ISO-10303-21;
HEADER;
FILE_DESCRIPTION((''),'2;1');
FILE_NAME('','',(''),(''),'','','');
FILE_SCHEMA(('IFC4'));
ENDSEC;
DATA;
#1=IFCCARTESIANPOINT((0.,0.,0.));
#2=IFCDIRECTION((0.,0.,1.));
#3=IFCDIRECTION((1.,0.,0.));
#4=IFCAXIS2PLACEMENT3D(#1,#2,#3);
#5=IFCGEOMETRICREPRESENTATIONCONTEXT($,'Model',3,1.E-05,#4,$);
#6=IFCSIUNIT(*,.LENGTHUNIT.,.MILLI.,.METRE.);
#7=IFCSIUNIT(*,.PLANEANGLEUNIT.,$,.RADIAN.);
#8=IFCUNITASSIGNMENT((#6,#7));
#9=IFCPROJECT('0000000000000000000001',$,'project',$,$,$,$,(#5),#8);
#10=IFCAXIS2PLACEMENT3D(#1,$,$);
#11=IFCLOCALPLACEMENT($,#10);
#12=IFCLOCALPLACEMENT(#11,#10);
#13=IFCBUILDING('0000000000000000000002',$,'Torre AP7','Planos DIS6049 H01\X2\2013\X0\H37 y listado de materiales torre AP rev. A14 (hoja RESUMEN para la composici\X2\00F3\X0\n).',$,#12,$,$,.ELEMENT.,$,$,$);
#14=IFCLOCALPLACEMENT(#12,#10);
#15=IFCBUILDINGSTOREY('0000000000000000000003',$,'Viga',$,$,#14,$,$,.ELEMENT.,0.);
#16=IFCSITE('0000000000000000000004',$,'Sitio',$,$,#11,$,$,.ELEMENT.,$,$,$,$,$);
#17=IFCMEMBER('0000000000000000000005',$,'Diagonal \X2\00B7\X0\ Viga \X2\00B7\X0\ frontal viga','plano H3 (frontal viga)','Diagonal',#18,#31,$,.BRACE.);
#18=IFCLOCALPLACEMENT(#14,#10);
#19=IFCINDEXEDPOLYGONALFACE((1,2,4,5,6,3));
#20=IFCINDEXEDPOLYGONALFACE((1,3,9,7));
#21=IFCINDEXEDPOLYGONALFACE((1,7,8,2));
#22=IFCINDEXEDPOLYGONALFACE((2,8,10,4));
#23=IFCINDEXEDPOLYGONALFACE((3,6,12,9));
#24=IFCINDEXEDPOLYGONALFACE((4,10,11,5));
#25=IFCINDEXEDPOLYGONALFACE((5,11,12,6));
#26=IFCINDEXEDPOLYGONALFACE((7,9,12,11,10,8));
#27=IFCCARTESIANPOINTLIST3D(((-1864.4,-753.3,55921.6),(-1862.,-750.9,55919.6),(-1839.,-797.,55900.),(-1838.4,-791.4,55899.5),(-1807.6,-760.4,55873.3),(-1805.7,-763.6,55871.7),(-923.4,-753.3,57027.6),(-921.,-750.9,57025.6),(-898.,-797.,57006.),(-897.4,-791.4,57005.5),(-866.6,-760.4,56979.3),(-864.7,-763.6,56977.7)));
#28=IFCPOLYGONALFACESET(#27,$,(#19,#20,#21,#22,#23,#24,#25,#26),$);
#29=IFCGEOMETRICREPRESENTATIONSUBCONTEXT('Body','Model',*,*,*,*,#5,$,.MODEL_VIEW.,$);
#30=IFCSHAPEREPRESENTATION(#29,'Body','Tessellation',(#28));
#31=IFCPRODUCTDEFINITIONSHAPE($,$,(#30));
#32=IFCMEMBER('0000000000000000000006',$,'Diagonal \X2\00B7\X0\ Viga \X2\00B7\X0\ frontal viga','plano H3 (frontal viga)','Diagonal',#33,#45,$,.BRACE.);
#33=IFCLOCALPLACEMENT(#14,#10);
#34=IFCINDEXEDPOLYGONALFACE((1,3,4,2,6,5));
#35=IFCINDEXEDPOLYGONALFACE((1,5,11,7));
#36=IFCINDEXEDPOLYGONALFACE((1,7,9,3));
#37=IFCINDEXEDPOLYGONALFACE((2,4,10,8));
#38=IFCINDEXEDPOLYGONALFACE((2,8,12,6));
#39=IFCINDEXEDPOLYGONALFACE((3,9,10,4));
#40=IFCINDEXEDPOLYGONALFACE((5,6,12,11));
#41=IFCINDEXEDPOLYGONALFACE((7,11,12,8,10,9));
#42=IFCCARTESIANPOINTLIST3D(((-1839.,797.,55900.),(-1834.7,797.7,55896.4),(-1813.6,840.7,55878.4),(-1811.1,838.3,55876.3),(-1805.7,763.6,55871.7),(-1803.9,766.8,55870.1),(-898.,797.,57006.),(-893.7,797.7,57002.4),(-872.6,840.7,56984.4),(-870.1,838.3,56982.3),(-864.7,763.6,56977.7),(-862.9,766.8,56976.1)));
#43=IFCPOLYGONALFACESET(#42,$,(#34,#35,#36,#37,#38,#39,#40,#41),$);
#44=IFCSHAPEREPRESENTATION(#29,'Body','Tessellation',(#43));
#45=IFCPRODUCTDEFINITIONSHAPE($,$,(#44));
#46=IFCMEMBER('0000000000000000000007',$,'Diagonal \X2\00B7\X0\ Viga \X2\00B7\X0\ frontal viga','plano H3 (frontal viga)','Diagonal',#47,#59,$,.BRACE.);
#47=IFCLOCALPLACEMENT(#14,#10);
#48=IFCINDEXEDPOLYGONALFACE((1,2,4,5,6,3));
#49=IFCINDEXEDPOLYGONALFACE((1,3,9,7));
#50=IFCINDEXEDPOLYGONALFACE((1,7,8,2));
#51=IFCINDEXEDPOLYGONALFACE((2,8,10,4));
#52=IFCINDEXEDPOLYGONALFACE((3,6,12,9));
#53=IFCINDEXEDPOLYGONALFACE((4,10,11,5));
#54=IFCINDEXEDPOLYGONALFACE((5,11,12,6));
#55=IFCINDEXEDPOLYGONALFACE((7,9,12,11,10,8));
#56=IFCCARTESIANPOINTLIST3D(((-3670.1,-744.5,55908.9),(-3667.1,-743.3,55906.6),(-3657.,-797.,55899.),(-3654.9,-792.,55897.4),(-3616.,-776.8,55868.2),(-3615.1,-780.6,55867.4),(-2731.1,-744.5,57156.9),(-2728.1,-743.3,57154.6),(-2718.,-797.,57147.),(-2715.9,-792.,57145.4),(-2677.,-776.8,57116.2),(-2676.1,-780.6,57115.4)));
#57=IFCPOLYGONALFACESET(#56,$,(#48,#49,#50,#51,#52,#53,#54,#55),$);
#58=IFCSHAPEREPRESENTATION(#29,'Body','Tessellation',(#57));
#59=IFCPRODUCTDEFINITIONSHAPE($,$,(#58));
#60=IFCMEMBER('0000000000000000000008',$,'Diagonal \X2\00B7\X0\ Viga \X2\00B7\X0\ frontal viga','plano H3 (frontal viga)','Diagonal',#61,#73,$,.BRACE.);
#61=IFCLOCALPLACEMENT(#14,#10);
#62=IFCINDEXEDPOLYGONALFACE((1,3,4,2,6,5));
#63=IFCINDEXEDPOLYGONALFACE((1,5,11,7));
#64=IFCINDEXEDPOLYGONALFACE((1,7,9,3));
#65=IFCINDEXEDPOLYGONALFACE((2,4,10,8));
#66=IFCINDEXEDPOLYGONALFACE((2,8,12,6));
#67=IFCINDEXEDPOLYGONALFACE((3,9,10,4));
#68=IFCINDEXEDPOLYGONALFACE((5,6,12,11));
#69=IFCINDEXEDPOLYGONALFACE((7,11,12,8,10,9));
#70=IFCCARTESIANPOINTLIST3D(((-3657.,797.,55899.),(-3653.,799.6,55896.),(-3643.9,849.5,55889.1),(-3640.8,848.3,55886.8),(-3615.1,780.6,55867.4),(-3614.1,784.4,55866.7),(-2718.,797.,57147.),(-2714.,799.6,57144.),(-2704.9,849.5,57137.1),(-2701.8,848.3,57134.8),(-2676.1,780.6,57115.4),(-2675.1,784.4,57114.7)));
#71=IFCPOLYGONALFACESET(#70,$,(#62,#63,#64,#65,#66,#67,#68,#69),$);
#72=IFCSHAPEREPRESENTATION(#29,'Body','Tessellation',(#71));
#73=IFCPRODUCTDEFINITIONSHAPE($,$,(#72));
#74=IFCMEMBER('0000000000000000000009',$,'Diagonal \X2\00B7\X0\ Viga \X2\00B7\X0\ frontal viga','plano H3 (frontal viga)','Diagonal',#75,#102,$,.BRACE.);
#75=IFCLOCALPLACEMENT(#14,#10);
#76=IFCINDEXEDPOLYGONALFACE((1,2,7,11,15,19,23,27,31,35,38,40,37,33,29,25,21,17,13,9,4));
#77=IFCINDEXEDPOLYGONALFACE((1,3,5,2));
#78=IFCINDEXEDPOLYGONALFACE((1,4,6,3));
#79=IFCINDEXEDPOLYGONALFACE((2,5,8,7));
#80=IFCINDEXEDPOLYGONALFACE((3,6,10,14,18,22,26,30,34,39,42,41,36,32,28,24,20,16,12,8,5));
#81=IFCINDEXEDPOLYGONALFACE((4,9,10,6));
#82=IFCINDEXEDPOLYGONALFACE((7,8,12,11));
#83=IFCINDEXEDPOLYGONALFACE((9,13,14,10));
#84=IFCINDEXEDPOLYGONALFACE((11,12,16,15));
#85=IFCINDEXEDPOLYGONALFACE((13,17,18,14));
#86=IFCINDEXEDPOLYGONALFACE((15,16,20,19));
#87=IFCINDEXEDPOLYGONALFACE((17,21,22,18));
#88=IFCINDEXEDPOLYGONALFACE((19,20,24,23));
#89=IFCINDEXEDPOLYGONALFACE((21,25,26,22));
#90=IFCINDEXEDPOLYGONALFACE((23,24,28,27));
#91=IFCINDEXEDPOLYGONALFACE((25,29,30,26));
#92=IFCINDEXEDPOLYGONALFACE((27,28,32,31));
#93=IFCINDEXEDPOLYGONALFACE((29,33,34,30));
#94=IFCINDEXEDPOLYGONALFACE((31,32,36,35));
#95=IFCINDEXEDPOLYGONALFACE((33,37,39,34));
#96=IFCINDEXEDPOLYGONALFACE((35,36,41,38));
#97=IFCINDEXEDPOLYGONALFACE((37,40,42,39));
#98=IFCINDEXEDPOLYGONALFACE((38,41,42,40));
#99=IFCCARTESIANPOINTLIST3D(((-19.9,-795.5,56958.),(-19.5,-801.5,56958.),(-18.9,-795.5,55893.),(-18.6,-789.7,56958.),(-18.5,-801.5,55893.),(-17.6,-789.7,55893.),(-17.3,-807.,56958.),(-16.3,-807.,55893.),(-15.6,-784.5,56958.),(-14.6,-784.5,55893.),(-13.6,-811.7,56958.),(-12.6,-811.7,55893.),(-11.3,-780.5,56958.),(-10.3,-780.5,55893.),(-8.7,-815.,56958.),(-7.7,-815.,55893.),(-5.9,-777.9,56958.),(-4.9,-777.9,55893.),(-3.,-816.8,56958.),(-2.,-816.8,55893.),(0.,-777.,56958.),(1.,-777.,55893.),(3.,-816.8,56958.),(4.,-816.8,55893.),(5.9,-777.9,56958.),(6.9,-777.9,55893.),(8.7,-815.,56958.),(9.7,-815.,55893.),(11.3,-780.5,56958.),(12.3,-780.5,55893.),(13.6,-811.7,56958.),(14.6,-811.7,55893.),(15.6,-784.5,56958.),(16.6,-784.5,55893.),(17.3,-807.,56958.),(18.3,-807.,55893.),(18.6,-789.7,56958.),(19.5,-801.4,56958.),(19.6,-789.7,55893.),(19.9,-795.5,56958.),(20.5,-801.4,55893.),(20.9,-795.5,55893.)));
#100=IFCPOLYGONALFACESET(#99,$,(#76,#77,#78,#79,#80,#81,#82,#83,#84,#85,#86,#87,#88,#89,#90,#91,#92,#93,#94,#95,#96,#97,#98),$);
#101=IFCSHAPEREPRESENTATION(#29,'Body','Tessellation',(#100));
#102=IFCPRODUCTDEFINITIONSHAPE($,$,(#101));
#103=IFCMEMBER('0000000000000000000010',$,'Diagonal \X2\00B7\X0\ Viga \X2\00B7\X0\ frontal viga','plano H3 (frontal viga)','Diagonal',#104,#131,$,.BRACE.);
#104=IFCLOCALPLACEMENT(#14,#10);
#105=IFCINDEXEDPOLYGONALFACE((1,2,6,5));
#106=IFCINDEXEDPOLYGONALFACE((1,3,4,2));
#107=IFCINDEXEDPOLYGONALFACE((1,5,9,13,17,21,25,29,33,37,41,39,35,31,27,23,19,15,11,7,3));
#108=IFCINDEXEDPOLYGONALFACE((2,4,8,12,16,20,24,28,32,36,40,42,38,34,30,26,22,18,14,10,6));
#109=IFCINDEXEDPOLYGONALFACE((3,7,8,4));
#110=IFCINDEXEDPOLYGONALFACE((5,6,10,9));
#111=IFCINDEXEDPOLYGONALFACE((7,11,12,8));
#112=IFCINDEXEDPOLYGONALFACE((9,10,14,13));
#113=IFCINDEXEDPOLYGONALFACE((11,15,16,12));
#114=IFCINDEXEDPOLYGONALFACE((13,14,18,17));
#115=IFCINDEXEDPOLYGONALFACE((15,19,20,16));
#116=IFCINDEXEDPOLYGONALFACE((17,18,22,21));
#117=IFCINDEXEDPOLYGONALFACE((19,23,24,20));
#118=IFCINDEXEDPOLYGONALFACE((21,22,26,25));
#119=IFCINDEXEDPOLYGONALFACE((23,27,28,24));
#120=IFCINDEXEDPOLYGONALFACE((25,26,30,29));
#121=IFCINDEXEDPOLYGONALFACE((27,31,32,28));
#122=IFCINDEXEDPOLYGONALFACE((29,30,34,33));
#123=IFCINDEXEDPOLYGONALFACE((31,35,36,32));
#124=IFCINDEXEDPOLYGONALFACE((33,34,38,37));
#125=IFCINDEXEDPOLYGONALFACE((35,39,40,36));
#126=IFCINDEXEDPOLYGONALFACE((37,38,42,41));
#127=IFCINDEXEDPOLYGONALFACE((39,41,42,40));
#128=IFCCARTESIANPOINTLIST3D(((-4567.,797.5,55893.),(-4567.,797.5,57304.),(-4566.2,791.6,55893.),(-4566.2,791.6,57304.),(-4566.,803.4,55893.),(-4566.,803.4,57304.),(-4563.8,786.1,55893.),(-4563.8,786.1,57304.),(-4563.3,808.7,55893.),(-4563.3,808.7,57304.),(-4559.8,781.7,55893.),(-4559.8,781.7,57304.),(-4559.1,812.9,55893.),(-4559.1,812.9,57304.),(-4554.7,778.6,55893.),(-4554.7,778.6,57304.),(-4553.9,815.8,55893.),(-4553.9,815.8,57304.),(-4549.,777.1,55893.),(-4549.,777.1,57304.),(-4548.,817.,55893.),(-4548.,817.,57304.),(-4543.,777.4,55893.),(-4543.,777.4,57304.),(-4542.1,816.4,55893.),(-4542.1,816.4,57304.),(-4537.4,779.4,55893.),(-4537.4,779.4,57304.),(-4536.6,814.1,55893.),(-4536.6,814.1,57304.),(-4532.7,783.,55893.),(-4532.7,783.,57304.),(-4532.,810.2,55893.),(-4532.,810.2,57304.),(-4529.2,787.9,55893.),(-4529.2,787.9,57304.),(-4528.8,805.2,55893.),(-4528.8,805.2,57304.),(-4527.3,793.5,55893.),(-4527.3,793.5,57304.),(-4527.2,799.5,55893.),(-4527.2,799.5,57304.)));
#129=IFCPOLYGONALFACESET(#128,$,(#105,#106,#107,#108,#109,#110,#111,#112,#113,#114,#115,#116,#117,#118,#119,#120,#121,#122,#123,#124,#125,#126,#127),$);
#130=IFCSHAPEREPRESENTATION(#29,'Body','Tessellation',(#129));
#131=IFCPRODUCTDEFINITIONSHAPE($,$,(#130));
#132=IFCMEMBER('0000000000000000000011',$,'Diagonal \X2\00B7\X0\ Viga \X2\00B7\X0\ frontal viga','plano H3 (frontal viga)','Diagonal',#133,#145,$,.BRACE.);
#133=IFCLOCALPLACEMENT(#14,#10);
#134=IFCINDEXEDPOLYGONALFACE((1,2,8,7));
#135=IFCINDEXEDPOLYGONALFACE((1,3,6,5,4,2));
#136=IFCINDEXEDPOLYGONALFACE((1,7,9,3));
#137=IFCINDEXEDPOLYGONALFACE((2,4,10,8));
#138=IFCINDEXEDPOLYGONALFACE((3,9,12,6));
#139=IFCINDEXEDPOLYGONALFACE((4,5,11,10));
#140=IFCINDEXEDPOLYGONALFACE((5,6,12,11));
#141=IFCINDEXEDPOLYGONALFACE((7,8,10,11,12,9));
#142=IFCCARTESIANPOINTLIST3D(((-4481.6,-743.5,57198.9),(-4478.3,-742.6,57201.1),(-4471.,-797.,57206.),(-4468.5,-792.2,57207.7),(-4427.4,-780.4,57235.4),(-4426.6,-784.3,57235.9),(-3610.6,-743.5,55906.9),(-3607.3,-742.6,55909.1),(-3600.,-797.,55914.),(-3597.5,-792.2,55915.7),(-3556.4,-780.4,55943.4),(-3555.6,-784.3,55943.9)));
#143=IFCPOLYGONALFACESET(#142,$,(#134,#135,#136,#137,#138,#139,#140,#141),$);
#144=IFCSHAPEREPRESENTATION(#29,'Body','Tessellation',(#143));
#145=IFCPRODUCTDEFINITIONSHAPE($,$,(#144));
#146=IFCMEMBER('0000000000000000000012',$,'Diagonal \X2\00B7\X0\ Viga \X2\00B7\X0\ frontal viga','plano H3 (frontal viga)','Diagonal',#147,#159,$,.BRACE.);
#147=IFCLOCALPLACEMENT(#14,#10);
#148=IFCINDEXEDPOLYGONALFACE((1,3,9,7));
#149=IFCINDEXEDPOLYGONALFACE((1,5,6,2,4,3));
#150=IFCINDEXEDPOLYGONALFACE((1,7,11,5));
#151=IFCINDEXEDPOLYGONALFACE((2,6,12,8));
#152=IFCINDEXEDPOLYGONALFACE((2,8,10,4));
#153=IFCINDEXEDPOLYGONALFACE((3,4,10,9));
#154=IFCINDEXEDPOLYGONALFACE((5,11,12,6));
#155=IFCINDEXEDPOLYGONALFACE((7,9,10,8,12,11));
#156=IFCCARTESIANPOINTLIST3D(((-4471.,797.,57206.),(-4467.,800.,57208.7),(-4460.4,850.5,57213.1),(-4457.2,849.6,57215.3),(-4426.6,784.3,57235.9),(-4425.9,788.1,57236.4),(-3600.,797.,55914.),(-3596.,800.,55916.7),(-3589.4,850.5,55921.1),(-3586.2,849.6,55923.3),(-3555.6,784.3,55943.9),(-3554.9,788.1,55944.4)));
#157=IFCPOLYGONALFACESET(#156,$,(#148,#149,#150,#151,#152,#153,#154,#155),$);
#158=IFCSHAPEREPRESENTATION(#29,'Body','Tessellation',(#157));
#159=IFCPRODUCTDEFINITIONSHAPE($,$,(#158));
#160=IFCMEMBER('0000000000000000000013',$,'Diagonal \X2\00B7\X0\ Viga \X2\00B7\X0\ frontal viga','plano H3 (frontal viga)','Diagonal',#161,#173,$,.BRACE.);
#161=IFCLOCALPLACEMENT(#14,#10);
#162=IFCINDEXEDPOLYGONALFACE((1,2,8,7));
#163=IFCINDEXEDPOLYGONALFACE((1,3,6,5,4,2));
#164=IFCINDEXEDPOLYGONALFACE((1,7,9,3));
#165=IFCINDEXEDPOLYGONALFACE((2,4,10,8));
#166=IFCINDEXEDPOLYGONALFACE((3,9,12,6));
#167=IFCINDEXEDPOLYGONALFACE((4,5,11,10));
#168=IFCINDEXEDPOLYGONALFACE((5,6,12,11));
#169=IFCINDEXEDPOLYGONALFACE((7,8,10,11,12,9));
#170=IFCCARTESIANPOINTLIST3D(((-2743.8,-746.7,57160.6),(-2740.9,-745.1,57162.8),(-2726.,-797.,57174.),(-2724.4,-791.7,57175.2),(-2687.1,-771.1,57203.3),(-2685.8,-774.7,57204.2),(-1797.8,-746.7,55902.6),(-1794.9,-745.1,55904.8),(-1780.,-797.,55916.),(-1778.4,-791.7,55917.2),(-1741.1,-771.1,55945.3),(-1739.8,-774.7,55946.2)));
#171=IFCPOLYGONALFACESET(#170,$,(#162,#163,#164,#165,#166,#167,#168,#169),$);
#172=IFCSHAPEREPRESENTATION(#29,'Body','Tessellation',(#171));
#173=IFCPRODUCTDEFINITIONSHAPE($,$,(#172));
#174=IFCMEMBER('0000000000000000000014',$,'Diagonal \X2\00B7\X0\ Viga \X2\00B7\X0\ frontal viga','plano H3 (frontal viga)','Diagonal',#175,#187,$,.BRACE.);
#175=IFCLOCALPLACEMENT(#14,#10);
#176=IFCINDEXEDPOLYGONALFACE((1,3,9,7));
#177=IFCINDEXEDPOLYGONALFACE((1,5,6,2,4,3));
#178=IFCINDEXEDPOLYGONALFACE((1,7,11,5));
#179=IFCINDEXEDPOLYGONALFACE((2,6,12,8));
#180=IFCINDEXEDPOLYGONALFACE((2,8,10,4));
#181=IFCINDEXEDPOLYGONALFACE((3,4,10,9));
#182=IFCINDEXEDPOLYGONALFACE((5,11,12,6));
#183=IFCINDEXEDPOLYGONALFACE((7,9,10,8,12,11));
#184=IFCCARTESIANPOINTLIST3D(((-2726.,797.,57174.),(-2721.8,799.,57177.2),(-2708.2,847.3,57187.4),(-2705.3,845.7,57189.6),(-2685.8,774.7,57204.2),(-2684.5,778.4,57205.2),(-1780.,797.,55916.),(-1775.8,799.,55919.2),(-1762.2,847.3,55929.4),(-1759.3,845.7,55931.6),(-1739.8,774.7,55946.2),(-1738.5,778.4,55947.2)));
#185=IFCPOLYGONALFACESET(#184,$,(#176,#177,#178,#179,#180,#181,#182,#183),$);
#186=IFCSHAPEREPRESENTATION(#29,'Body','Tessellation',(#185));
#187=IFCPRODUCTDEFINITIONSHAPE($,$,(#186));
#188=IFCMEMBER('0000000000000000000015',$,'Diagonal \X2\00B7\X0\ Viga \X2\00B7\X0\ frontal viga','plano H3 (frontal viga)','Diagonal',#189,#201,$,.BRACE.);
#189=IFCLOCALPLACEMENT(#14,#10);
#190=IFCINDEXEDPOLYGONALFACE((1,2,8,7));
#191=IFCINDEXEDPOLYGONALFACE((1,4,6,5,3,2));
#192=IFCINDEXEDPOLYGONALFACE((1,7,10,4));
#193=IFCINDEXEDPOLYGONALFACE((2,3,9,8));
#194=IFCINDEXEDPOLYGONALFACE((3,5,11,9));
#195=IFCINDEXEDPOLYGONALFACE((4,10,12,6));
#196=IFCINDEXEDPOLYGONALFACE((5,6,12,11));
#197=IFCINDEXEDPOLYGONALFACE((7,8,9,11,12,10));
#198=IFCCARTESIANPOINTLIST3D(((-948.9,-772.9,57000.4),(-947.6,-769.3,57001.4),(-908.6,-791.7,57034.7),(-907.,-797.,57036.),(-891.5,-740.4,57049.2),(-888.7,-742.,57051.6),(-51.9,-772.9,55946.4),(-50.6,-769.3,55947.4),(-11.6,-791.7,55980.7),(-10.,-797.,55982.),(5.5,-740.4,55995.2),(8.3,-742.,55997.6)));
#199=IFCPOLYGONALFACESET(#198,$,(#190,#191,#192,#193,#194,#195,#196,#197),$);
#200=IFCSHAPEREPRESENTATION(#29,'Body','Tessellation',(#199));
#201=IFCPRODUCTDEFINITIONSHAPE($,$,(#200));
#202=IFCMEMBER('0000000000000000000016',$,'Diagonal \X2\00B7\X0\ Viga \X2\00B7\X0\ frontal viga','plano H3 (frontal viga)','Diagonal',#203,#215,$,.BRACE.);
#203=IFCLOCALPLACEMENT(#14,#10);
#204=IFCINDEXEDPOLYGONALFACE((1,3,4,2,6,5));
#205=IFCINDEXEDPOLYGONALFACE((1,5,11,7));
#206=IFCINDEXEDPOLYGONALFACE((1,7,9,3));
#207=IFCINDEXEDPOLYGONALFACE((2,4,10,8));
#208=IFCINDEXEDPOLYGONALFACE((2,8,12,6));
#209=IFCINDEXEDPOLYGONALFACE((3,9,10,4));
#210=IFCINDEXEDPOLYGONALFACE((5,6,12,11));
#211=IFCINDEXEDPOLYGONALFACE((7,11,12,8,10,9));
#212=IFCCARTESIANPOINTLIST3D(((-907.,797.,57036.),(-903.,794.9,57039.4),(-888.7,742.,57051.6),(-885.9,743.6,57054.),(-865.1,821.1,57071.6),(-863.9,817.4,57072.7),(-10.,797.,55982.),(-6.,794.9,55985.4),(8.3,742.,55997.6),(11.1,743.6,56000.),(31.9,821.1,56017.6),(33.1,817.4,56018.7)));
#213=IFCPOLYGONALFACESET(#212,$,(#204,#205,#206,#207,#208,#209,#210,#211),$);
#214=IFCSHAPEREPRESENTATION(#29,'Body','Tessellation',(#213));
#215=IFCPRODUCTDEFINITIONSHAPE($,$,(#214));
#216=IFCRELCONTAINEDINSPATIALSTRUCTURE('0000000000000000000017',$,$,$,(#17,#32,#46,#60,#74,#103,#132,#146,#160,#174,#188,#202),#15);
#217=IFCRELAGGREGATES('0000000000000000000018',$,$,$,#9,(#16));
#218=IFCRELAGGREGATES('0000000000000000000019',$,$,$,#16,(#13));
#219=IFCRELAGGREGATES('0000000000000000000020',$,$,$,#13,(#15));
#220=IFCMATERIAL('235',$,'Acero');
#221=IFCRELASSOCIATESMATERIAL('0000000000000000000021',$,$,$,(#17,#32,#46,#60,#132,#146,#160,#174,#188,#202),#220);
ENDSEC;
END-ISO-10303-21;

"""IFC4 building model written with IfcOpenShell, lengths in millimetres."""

from ifc_helpers import new_model, si_unit, frame, frame_2d, origin, origin_with_axes, place, context, subcontext, project, spatial, circle, l_section, extrude, material, element, save


model = new_model("IFC4")

# Units and contexts
model_context = context("Model", 3, precision=1e-05, world=origin_with_axes())
body_context = subcontext(model_context, "Body", "Model", "MODEL_VIEW")
ifc_project = project(units=[si_unit("LENGTHUNIT", "METRE", prefix="MILLI"), si_unit("PLANEANGLEUNIT", "RADIAN")], contexts=[model_context])

# Site, building, storey
site_placement = place(None, origin())
site = spatial("IfcSite", under=ifc_project, at=site_placement, Name="Sitio", CompositionType="ELEMENT")
building_placement = place(site_placement, origin())
building = spatial("IfcBuilding", under=site, at=building_placement, Name="Torre AP7", Description="Planos DIS6049 H01–H37 y listado de materiales torre AP rev. A14 (hoja RESUMEN para la composición).", CompositionType="ELEMENT")
storey_placement = place(building_placement, origin())
storey = spatial("IfcBuildingStorey", under=building, at=storey_placement, Name="Viga", CompositionType="ELEMENT", Elevation=0.0)

# Members
ifc_material = material(Name="235", Category="Acero")
for number, where, z_axis, x_axis, name in (
    (1, (-1839.0, -797.0, 55900.0), (0.648008, 0.0, 0.761633), (0.605023, 0.607426, -0.514762), "Diagonal · Viga · frontal viga"),
    (2, (-1839.0, 797.0, 55900.0), (0.648008, 0.0, 0.761633), (0.605023, -0.607426, -0.514762), "Diagonal · Viga · frontal viga"),
):
    element("IfcMember", number, at=place(storey_placement, frame(where, z_axis=z_axis, x_axis=x_axis)), inside=storey, material=ifc_material, Name=name, Description="plano H3 (frontal viga)", ObjectType="Diagonal", PredefinedType="BRACE", context=body_context, shape_type="SweptSolid", body=[
        extrude(l_section(Depth=55.0, Width=55.0, Thickness=4.0, at=frame_2d((27.5, 27.5))), None, (0.0, 0.0, 1.0), 1452.1),
    ])
for number, where, z_axis, x_axis, name in (
    (3, (-3657.0, -797.0, 55899.0), (0.601229, 0.0, 0.799077), (0.762614, 0.298631, -0.573794), "Diagonal · Viga · frontal viga"),
    (4, (-3657.0, 797.0, 55899.0), (0.601229, 0.0, 0.799077), (0.762614, -0.298631, -0.573794), "Diagonal · Viga · frontal viga"),
):
    element("IfcMember", number, at=place(storey_placement, frame(where, z_axis=z_axis, x_axis=x_axis)), inside=storey, material=ifc_material, Name=name, Description="plano H3 (frontal viga)", ObjectType="Diagonal", PredefinedType="BRACE", context=body_context, shape_type="SweptSolid", body=[
        extrude(l_section(Depth=55.0, Width=55.0, Thickness=4.0, at=frame_2d((27.5, 27.5))), None, (0.0, 0.0, 1.0), 1561.8),
    ])
member_1_placement = place(storey_placement, frame((1.0, -797.0, 55893.0), z_axis=(-0.000939, 0.0, 1.0), x_axis=(-0.000627, 1.0, -0.000001)))
element("IfcMember", 5, at=member_1_placement, inside=storey, Name="Diagonal · Viga · frontal viga", Description="plano H3 (frontal viga)", ObjectType="Diagonal", PredefinedType="BRACE", context=body_context, shape_type="SweptSolid", body=[
    extrude(circle(Radius=20.0), None, (0.0, 0.0, 1.0), 1065.0),
])
member_2_placement = place(storey_placement, frame((-4547.0, 797.0, 55893.0), z_axis=(0.0, 0.0, 1.0), x_axis=(0.984984, -0.172648, 0.0)))
element("IfcMember", 6, at=member_2_placement, inside=storey, Name="Diagonal · Viga · frontal viga", Description="plano H3 (frontal viga)", ObjectType="Diagonal", PredefinedType="BRACE", context=body_context, shape_type="SweptSolid", body=[
    extrude(circle(Radius=20.0), None, (0.0, 0.0, 1.0), 1411.0),
])
for number, where, z_axis, x_axis, name in (
    (7, (-3600.0, -797.0, 55914.0), (-0.558988, 0.0, 0.829176), (0.806611, 0.231703, 0.543776), "Diagonal · Viga · frontal viga"),
    (8, (-3600.0, 797.0, 55914.0), (-0.558988, 0.0, 0.829176), (0.806611, -0.231703, 0.543776), "Diagonal · Viga · frontal viga"),
):
    element("IfcMember", number, at=place(storey_placement, frame(where, z_axis=z_axis, x_axis=x_axis)), inside=storey, material=ifc_material, Name=name, Description="plano H3 (frontal viga)", ObjectType="Diagonal", PredefinedType="BRACE", context=body_context, shape_type="SweptSolid", body=[
        extrude(l_section(Depth=55.0, Width=55.0, Thickness=4.0, at=frame_2d((27.5, 27.5))), None, (0.0, 0.0, 1.0), 1558.2),
    ])
for number, where, z_axis, x_axis, name in (
    (9, (-1780.0, -797.0, 55916.0), (-0.601016, 0.0, 0.799237), (0.730849, 0.404737, 0.549589), "Diagonal · Viga · frontal viga"),
    (10, (-1780.0, 797.0, 55916.0), (-0.601016, 0.0, 0.799237), (0.730849, -0.404737, 0.549589), "Diagonal · Viga · frontal viga"),
):
    element("IfcMember", number, at=place(storey_placement, frame(where, z_axis=z_axis, x_axis=x_axis)), inside=storey, material=ifc_material, Name=name, Description="plano H3 (frontal viga)", ObjectType="Diagonal", PredefinedType="BRACE", context=body_context, shape_type="SweptSolid", body=[
        extrude(l_section(Depth=55.0, Width=55.0, Thickness=4.0, at=frame_2d((27.5, 27.5))), None, (0.0, 0.0, 1.0), 1574.0),
    ])
for number, where, z_axis, x_axis, name in (
    (11, (-10.0, -797.0, 55982.0), (-0.64811, 0.0, 0.761547), (0.305596, 0.915954, 0.260076), "Diagonal · Viga · frontal viga"),
    (12, (-10.0, 797.0, 55982.0), (-0.64811, 0.0, 0.761547), (0.305596, -0.915954, 0.260076), "Diagonal · Viga · frontal viga"),
):
    element("IfcMember", number, at=place(storey_placement, frame(where, z_axis=z_axis, x_axis=x_axis)), inside=storey, material=ifc_material, Name=name, Description="plano H3 (frontal viga)", ObjectType="Diagonal", PredefinedType="BRACE", context=body_context, shape_type="SweptSolid", body=[
        extrude(l_section(Depth=60.0, Width=60.0, Thickness=4.0, at=frame_2d((30.0, 30.0))), None, (0.0, 0.0, 1.0), 1384.0),
    ])

save(model, "model.ifc")
